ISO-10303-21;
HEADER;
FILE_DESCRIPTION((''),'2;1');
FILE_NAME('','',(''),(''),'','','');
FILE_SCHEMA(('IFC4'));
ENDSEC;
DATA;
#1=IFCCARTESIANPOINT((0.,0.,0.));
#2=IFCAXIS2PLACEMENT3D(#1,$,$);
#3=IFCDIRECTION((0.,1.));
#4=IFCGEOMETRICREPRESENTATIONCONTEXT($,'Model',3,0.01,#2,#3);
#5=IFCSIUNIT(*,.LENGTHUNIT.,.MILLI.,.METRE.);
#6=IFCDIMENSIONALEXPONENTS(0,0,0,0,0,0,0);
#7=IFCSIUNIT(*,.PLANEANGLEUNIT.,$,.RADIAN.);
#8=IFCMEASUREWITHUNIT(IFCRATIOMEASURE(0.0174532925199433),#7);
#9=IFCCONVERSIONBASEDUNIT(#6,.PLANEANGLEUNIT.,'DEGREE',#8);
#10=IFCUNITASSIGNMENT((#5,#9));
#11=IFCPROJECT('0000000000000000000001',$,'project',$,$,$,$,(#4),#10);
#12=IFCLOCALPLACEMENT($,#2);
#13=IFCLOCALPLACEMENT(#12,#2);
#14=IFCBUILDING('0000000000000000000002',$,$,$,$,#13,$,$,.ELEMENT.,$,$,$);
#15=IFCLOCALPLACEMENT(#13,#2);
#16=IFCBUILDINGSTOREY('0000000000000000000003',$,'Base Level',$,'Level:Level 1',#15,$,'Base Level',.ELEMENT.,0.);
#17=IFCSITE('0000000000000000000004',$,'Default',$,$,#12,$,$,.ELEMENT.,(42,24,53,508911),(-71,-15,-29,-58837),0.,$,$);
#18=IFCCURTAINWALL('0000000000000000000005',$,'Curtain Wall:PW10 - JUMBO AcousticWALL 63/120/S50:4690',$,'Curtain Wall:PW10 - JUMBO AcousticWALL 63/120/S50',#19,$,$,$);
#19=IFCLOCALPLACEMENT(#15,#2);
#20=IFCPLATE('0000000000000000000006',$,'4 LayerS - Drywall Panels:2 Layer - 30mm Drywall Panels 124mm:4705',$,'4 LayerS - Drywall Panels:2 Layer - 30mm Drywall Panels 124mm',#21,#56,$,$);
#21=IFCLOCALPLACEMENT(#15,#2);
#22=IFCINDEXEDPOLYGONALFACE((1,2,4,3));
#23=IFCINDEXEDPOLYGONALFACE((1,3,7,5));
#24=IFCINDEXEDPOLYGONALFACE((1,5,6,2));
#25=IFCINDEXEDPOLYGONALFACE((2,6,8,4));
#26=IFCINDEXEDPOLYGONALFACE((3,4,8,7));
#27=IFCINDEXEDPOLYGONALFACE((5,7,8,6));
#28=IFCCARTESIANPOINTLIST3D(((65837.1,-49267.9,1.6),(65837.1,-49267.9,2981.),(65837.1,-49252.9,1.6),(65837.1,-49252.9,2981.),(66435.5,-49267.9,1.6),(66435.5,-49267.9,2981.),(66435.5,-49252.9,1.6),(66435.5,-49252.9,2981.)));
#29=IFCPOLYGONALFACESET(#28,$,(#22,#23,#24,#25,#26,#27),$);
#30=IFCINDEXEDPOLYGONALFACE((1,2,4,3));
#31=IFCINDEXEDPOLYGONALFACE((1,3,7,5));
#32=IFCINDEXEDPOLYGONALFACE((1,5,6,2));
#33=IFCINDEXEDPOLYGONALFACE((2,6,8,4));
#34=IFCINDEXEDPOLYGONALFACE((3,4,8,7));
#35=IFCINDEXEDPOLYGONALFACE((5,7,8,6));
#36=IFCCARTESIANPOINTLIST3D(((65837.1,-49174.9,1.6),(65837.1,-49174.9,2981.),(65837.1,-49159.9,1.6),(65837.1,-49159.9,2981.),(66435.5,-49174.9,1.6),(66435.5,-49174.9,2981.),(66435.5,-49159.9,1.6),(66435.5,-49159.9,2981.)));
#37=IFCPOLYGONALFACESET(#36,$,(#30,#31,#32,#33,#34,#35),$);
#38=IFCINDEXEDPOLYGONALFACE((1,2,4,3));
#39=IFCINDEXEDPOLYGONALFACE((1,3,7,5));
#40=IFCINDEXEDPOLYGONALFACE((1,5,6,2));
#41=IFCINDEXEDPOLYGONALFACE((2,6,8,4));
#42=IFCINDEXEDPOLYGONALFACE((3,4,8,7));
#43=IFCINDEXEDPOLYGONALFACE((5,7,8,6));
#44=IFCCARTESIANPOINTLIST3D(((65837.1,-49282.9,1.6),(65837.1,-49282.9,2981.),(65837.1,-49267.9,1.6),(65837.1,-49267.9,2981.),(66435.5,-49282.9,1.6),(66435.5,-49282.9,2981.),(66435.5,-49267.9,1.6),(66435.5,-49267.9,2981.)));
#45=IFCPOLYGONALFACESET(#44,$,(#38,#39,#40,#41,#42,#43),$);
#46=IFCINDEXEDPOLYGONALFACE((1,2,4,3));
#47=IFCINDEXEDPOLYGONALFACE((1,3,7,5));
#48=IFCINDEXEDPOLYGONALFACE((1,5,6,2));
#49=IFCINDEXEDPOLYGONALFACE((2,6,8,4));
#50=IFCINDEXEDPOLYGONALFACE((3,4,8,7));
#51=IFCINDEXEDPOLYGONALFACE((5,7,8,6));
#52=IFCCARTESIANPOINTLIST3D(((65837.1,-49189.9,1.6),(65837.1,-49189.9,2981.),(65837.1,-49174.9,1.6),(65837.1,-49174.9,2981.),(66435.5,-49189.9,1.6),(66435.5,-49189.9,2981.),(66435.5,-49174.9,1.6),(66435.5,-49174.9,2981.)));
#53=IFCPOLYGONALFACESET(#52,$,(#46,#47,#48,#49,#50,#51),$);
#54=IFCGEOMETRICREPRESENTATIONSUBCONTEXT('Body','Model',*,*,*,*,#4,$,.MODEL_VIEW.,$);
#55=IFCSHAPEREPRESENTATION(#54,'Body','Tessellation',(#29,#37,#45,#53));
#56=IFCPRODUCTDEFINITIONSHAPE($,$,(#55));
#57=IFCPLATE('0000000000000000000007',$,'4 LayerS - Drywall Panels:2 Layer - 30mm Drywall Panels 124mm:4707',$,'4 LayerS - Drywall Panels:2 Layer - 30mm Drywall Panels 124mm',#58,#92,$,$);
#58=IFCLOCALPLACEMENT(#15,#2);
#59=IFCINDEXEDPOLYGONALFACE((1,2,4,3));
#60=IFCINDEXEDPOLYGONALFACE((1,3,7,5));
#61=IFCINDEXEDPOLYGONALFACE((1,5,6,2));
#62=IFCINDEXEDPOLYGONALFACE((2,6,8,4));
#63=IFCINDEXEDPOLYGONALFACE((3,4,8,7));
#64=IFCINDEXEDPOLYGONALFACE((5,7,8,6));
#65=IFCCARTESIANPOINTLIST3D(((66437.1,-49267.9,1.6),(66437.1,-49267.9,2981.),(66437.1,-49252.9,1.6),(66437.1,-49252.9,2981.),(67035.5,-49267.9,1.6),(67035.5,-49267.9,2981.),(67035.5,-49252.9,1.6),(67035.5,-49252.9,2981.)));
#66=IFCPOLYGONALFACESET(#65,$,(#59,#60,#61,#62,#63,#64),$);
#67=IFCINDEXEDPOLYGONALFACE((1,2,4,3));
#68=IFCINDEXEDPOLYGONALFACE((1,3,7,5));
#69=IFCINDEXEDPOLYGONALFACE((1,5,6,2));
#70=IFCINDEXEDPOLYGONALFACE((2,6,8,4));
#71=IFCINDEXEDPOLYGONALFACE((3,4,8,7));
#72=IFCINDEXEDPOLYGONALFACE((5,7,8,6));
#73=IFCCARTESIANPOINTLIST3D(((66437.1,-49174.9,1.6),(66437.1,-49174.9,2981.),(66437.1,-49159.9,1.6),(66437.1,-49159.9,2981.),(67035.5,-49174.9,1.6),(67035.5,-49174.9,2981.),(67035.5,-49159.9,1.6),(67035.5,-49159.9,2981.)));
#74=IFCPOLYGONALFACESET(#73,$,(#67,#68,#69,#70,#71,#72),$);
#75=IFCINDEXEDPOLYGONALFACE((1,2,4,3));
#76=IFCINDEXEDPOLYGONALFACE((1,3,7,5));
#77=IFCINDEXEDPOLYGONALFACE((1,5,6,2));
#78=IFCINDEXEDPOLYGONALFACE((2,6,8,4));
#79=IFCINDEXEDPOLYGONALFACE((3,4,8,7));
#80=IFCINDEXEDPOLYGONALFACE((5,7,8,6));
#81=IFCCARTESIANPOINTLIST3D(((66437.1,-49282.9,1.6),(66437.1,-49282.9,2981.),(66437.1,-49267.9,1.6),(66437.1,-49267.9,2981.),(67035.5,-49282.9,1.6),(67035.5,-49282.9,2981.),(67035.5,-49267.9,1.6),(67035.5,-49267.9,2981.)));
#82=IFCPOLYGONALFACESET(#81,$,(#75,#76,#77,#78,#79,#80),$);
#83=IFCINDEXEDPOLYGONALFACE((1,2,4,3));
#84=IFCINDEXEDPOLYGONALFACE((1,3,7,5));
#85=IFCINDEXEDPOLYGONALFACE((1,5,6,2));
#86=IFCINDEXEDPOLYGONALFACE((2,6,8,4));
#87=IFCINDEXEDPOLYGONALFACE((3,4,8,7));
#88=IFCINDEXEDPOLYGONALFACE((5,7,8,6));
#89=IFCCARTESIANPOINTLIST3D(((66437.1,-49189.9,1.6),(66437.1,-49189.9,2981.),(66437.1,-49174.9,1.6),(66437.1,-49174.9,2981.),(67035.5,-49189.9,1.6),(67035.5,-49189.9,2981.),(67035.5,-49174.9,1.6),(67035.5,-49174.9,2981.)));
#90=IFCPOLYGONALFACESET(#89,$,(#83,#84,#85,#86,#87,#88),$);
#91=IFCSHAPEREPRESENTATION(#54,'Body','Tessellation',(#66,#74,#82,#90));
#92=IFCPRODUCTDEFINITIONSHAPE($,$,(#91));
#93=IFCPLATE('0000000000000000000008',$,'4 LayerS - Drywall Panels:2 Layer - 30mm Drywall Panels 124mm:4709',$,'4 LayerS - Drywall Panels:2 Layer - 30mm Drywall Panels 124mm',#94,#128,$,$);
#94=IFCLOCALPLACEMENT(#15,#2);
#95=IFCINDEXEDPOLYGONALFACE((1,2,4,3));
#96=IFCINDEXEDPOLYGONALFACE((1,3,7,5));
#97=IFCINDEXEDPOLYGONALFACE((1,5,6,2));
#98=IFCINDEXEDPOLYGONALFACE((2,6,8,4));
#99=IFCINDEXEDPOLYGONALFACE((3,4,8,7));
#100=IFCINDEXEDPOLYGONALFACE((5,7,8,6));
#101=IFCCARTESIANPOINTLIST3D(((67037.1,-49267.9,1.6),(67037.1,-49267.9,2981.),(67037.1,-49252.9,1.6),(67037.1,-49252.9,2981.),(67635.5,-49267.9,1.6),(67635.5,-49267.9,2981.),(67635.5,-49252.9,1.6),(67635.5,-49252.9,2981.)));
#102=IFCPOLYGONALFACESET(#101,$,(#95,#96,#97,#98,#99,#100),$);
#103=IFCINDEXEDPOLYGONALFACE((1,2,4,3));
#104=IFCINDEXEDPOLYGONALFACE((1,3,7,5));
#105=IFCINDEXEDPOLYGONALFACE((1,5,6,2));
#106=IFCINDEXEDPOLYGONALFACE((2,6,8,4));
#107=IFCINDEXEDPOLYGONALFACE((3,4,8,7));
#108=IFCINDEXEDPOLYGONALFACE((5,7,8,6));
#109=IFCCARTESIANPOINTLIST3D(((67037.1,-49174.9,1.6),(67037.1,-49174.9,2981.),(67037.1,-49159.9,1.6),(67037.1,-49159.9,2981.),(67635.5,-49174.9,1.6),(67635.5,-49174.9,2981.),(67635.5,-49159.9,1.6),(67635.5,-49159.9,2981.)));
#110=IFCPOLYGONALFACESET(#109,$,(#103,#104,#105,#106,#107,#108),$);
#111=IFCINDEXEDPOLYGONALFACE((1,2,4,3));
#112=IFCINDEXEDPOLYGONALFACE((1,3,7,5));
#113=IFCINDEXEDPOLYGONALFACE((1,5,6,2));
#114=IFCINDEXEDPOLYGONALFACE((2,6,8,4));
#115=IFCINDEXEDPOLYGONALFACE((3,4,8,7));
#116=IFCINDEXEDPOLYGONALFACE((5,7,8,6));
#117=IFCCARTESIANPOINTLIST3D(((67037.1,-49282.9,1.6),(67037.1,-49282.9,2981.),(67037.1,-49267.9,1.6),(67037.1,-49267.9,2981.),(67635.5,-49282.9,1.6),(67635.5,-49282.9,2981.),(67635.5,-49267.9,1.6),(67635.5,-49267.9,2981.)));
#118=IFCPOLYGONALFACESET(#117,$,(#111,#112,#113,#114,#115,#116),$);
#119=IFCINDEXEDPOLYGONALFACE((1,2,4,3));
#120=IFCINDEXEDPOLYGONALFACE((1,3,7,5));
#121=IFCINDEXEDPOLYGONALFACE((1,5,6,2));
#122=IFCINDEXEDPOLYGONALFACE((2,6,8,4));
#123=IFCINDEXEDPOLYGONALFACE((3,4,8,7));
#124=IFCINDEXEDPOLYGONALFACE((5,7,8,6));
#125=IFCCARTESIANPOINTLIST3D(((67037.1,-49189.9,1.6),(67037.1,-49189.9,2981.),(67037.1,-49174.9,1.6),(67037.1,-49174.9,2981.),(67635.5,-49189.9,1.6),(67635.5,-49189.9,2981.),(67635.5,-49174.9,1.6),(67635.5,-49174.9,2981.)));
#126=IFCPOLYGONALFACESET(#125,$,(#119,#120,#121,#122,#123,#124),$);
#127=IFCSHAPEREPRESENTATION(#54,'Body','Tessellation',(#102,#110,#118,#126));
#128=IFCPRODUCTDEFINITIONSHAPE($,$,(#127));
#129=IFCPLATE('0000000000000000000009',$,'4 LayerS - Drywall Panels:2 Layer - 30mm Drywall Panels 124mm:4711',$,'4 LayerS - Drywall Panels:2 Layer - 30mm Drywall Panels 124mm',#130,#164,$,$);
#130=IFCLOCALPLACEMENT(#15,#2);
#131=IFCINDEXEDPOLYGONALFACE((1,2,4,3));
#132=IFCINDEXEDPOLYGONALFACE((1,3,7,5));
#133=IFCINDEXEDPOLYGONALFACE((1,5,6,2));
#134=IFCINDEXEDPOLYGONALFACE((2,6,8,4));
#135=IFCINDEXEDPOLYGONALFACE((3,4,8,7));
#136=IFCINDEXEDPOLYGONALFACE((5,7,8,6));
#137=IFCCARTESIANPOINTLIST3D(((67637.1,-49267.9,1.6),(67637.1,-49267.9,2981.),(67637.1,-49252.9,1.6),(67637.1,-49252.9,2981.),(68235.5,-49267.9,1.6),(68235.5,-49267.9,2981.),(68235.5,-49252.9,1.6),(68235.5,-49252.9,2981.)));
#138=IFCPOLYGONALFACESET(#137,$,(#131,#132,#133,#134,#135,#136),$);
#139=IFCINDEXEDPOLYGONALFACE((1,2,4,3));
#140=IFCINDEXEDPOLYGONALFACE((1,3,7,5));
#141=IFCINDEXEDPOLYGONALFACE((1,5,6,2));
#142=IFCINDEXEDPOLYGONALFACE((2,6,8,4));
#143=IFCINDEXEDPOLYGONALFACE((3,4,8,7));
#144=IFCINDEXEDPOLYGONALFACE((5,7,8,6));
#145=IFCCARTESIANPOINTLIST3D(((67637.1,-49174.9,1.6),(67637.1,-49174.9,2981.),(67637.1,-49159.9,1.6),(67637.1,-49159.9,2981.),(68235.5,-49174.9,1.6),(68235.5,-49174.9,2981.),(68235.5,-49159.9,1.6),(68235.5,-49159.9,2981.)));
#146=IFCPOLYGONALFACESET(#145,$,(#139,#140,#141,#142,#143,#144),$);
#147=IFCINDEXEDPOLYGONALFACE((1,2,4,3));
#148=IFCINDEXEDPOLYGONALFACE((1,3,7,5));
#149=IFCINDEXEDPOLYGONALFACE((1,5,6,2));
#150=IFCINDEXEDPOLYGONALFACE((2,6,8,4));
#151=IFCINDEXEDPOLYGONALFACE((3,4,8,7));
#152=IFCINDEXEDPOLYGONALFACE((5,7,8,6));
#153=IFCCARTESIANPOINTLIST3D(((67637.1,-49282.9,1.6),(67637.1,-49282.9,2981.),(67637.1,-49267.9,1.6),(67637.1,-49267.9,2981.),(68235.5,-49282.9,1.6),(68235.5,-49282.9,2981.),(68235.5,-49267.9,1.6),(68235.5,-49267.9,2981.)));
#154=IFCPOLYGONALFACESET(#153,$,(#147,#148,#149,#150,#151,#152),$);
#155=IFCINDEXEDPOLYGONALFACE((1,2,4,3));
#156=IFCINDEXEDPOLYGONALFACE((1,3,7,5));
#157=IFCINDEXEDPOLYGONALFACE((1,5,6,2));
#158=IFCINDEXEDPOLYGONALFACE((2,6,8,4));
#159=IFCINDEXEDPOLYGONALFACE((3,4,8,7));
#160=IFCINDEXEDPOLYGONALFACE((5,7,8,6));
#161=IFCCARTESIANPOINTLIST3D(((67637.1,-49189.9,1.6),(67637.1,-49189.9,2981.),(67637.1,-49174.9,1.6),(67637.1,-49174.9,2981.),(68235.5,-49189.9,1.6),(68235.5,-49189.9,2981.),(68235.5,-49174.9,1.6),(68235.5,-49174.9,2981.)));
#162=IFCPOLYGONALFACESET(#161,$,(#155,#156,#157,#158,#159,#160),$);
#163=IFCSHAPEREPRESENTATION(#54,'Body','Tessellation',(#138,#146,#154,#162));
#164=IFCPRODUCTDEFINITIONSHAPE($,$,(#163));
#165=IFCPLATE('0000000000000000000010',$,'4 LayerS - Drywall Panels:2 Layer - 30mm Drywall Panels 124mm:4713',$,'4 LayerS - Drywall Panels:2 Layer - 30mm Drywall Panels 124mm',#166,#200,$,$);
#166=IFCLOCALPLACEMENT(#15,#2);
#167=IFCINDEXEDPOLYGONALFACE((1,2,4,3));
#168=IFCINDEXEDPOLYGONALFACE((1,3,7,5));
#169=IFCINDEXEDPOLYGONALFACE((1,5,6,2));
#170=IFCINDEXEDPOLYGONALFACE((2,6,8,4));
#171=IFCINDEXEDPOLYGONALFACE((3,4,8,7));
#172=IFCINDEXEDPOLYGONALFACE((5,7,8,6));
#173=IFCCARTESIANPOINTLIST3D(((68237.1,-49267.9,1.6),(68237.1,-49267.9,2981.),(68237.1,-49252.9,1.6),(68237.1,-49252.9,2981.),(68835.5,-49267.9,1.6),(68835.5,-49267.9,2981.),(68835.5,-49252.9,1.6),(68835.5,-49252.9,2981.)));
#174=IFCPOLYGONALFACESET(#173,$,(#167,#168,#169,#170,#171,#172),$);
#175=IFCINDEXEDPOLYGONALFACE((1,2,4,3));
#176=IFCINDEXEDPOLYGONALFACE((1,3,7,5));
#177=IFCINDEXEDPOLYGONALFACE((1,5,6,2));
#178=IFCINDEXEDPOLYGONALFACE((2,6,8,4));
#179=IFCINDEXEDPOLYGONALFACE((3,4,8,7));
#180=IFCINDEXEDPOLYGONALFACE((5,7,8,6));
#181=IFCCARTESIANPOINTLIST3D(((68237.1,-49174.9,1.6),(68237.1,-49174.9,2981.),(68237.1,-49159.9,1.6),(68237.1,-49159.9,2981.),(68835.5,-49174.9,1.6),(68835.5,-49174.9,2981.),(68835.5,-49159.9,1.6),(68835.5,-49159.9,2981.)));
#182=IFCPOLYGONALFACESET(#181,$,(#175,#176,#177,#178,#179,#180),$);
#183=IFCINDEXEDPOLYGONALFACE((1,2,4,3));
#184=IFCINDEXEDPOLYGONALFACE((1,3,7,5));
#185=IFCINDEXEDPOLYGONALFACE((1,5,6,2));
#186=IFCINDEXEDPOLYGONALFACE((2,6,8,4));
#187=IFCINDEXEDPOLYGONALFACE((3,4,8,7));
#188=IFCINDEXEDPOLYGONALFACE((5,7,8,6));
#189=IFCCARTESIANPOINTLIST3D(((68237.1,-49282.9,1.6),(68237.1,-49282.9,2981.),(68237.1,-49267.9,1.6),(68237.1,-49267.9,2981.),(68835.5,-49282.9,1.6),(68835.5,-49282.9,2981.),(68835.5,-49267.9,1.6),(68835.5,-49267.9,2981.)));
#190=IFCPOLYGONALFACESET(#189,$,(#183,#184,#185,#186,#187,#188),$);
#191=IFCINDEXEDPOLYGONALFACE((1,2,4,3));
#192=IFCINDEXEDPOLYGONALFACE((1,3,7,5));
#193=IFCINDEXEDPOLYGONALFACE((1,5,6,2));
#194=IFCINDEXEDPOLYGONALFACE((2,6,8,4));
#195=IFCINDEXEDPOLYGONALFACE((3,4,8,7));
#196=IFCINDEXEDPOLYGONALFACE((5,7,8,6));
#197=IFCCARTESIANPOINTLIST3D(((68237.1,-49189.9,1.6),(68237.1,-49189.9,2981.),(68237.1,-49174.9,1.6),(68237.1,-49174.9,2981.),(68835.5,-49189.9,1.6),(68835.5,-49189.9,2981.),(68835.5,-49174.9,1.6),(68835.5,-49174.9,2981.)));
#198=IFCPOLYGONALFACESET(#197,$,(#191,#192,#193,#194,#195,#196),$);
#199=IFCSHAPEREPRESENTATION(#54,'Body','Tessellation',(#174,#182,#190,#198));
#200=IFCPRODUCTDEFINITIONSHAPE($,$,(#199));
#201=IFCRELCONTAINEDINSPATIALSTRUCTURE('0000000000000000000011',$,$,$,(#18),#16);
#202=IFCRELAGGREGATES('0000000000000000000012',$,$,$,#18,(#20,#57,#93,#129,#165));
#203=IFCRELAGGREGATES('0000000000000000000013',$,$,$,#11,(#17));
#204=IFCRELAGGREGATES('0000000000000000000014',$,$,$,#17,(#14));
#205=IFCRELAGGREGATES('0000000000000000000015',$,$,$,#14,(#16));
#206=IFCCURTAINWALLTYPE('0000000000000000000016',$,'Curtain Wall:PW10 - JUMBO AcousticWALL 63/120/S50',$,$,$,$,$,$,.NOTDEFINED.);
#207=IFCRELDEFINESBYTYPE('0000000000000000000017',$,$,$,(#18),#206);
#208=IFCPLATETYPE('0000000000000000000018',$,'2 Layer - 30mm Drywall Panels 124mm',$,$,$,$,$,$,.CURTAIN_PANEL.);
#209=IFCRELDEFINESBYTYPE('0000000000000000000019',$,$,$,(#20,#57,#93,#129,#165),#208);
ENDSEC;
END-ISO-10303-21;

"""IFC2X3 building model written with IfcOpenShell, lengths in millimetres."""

from ifc_helpers import new_model, entity, si_unit, converted_unit, direction, frame, frame_2d, origin, origin_2d_with_axis, place, context, subcontext, project, spatial, rectangle, extrude, source, transform, mapped, type_object, type_shapes, element, aggregate, save


model = new_model("IFC2X3")

# Units and contexts
model_context = context("Model", 3, precision=0.01, world=origin(), true_north=direction((0.0, 1.0)))
body_context = subcontext(model_context, "Body", "Model", "MODEL_VIEW")
ifc_project = project(units=[si_unit("LENGTHUNIT", "METRE", prefix="MILLI"), converted_unit("PLANEANGLEUNIT", "DEGREE", entity("IfcRatioMeasure", 0.0174532925199433), si_unit("PLANEANGLEUNIT", "RADIAN"), dimensions=[0, 0, 0, 0, 0, 0, 0])], contexts=[model_context])

# Site, building, storey
site_placement = place(None, origin())
site = spatial("IfcSite", under=ifc_project, at=site_placement, Name="Default", CompositionType="ELEMENT", RefLatitude=(42, 24, 53, 508911), RefLongitude=(-71, -15, -29, -58837), RefElevation=0.0)
building_placement = place(site_placement, origin())
building = spatial("IfcBuilding", under=site, at=building_placement, CompositionType="ELEMENT")
storey_placement = place(building_placement, origin())
storey = spatial("IfcBuildingStorey", under=building, at=storey_placement, Name="Base Level", ObjectType="Level:Level 1", LongName="Base Level", CompositionType="ELEMENT", Elevation=0.0)

# Curtain wall, plates
curtain_wall_type = type_object("IfcCurtainWallType", Name="Curtain Wall:PW10 - JUMBO AcousticWALL 63/120/S50", PredefinedType="NOTDEFINED")
curtain_wall_placement = place(building_placement, origin())
curtain_wall = element("IfcCurtainWall", 1, at=curtain_wall_placement, inside=storey, type_object=curtain_wall_type, Name="Curtain Wall:PW10 - JUMBO AcousticWALL 63/120/S50:4690", ObjectType="Curtain Wall:PW10 - JUMBO AcousticWALL 63/120/S50")
plate_type = type_object("IfcPlateType", Name="2 Layer - 30mm Drywall Panels 124mm", PredefinedType="CURTAIN_PANEL")
shared_shape_1 = source(origin(), body_context, "Body", "SweptSolid", [
    extrude(rectangle(XDim=15.0, YDim=598.4, at=origin_2d_with_axis()), frame((0.0, -39.0, 0.0), z_axis=(0.0, 0.0, 1.0), x_axis=(0.0, 1.0, 0.0)), (0.0, 0.0, 1.0), 2979.4),
    extrude(rectangle(XDim=15.0, YDim=598.4, at=origin_2d_with_axis()), frame((0.0, 54.0, 0.0), z_axis=(0.0, 0.0, 1.0), x_axis=(0.0, 1.0, 0.0)), (0.0, 0.0, 1.0), 2979.4),
    extrude(rectangle(XDim=598.4, YDim=15.0, at=frame_2d((0.0, 0.0), x_axis=(1.0, 0.0))), frame((0.0, -54.0, 0.0), z_axis=(0.0, 0.0, 1.0), x_axis=(-1.0, 0.0, 0.0)), (0.0, 0.0, 1.0), 2979.4),
    extrude(rectangle(XDim=15.0, YDim=598.4, at=frame_2d((0.0, 0.0), x_axis=(1.0, 0.0))), frame((0.0, 39.0, 0.0), z_axis=(0.0, 0.0, 1.0), x_axis=(0.0, 1.0, 0.0)), (0.0, 0.0, 1.0), 2979.4),
])
type_shapes(plate_type, [shared_shape_1])
plate_1_placement = place(curtain_wall_placement, frame((66136.3, -49221.4, 1.6)))
plate_1 = element("IfcPlate", 2, at=plate_1_placement, type_object=plate_type, Name="4 LayerS - Drywall Panels:2 Layer - 30mm Drywall Panels 124mm:4705", ObjectType="4 LayerS - Drywall Panels:2 Layer - 30mm Drywall Panels 124mm", context=body_context, shape_type="MappedRepresentation", body=[
    mapped(shared_shape_1, transform((0.0, 0.0, 0.0), scale=1.0)),
])
plate_2_placement = place(curtain_wall_placement, frame((66736.3, -49221.4, 1.6)))
plate_2 = element("IfcPlate", 3, at=plate_2_placement, type_object=plate_type, Name="4 LayerS - Drywall Panels:2 Layer - 30mm Drywall Panels 124mm:4707", ObjectType="4 LayerS - Drywall Panels:2 Layer - 30mm Drywall Panels 124mm", context=body_context, shape_type="MappedRepresentation", body=[
    mapped(shared_shape_1, transform((0.0, 0.0, 0.0), scale=1.0)),
])
plate_3_placement = place(curtain_wall_placement, frame((67336.3, -49221.4, 1.6)))
plate_3 = element("IfcPlate", 4, at=plate_3_placement, type_object=plate_type, Name="4 LayerS - Drywall Panels:2 Layer - 30mm Drywall Panels 124mm:4709", ObjectType="4 LayerS - Drywall Panels:2 Layer - 30mm Drywall Panels 124mm", context=body_context, shape_type="MappedRepresentation", body=[
    mapped(shared_shape_1, transform((0.0, 0.0, 0.0), scale=1.0)),
])
plate_4_placement = place(curtain_wall_placement, frame((67936.3, -49221.4, 1.6)))
plate_4 = element("IfcPlate", 5, at=plate_4_placement, type_object=plate_type, Name="4 LayerS - Drywall Panels:2 Layer - 30mm Drywall Panels 124mm:4711", ObjectType="4 LayerS - Drywall Panels:2 Layer - 30mm Drywall Panels 124mm", context=body_context, shape_type="MappedRepresentation", body=[
    mapped(shared_shape_1, transform((0.0, 0.0, 0.0), scale=1.0)),
])
plate_5_placement = place(curtain_wall_placement, frame((68536.3, -49221.4, 1.6)))
plate_5 = element("IfcPlate", 6, at=plate_5_placement, type_object=plate_type, Name="4 LayerS - Drywall Panels:2 Layer - 30mm Drywall Panels 124mm:4713", ObjectType="4 LayerS - Drywall Panels:2 Layer - 30mm Drywall Panels 124mm", context=body_context, shape_type="MappedRepresentation", body=[
    mapped(shared_shape_1, transform((0.0, 0.0, 0.0), scale=1.0)),
])
aggregate(curtain_wall, [plate_1, plate_2, plate_3, plate_4, plate_5])

save(model, "model.ifc")
